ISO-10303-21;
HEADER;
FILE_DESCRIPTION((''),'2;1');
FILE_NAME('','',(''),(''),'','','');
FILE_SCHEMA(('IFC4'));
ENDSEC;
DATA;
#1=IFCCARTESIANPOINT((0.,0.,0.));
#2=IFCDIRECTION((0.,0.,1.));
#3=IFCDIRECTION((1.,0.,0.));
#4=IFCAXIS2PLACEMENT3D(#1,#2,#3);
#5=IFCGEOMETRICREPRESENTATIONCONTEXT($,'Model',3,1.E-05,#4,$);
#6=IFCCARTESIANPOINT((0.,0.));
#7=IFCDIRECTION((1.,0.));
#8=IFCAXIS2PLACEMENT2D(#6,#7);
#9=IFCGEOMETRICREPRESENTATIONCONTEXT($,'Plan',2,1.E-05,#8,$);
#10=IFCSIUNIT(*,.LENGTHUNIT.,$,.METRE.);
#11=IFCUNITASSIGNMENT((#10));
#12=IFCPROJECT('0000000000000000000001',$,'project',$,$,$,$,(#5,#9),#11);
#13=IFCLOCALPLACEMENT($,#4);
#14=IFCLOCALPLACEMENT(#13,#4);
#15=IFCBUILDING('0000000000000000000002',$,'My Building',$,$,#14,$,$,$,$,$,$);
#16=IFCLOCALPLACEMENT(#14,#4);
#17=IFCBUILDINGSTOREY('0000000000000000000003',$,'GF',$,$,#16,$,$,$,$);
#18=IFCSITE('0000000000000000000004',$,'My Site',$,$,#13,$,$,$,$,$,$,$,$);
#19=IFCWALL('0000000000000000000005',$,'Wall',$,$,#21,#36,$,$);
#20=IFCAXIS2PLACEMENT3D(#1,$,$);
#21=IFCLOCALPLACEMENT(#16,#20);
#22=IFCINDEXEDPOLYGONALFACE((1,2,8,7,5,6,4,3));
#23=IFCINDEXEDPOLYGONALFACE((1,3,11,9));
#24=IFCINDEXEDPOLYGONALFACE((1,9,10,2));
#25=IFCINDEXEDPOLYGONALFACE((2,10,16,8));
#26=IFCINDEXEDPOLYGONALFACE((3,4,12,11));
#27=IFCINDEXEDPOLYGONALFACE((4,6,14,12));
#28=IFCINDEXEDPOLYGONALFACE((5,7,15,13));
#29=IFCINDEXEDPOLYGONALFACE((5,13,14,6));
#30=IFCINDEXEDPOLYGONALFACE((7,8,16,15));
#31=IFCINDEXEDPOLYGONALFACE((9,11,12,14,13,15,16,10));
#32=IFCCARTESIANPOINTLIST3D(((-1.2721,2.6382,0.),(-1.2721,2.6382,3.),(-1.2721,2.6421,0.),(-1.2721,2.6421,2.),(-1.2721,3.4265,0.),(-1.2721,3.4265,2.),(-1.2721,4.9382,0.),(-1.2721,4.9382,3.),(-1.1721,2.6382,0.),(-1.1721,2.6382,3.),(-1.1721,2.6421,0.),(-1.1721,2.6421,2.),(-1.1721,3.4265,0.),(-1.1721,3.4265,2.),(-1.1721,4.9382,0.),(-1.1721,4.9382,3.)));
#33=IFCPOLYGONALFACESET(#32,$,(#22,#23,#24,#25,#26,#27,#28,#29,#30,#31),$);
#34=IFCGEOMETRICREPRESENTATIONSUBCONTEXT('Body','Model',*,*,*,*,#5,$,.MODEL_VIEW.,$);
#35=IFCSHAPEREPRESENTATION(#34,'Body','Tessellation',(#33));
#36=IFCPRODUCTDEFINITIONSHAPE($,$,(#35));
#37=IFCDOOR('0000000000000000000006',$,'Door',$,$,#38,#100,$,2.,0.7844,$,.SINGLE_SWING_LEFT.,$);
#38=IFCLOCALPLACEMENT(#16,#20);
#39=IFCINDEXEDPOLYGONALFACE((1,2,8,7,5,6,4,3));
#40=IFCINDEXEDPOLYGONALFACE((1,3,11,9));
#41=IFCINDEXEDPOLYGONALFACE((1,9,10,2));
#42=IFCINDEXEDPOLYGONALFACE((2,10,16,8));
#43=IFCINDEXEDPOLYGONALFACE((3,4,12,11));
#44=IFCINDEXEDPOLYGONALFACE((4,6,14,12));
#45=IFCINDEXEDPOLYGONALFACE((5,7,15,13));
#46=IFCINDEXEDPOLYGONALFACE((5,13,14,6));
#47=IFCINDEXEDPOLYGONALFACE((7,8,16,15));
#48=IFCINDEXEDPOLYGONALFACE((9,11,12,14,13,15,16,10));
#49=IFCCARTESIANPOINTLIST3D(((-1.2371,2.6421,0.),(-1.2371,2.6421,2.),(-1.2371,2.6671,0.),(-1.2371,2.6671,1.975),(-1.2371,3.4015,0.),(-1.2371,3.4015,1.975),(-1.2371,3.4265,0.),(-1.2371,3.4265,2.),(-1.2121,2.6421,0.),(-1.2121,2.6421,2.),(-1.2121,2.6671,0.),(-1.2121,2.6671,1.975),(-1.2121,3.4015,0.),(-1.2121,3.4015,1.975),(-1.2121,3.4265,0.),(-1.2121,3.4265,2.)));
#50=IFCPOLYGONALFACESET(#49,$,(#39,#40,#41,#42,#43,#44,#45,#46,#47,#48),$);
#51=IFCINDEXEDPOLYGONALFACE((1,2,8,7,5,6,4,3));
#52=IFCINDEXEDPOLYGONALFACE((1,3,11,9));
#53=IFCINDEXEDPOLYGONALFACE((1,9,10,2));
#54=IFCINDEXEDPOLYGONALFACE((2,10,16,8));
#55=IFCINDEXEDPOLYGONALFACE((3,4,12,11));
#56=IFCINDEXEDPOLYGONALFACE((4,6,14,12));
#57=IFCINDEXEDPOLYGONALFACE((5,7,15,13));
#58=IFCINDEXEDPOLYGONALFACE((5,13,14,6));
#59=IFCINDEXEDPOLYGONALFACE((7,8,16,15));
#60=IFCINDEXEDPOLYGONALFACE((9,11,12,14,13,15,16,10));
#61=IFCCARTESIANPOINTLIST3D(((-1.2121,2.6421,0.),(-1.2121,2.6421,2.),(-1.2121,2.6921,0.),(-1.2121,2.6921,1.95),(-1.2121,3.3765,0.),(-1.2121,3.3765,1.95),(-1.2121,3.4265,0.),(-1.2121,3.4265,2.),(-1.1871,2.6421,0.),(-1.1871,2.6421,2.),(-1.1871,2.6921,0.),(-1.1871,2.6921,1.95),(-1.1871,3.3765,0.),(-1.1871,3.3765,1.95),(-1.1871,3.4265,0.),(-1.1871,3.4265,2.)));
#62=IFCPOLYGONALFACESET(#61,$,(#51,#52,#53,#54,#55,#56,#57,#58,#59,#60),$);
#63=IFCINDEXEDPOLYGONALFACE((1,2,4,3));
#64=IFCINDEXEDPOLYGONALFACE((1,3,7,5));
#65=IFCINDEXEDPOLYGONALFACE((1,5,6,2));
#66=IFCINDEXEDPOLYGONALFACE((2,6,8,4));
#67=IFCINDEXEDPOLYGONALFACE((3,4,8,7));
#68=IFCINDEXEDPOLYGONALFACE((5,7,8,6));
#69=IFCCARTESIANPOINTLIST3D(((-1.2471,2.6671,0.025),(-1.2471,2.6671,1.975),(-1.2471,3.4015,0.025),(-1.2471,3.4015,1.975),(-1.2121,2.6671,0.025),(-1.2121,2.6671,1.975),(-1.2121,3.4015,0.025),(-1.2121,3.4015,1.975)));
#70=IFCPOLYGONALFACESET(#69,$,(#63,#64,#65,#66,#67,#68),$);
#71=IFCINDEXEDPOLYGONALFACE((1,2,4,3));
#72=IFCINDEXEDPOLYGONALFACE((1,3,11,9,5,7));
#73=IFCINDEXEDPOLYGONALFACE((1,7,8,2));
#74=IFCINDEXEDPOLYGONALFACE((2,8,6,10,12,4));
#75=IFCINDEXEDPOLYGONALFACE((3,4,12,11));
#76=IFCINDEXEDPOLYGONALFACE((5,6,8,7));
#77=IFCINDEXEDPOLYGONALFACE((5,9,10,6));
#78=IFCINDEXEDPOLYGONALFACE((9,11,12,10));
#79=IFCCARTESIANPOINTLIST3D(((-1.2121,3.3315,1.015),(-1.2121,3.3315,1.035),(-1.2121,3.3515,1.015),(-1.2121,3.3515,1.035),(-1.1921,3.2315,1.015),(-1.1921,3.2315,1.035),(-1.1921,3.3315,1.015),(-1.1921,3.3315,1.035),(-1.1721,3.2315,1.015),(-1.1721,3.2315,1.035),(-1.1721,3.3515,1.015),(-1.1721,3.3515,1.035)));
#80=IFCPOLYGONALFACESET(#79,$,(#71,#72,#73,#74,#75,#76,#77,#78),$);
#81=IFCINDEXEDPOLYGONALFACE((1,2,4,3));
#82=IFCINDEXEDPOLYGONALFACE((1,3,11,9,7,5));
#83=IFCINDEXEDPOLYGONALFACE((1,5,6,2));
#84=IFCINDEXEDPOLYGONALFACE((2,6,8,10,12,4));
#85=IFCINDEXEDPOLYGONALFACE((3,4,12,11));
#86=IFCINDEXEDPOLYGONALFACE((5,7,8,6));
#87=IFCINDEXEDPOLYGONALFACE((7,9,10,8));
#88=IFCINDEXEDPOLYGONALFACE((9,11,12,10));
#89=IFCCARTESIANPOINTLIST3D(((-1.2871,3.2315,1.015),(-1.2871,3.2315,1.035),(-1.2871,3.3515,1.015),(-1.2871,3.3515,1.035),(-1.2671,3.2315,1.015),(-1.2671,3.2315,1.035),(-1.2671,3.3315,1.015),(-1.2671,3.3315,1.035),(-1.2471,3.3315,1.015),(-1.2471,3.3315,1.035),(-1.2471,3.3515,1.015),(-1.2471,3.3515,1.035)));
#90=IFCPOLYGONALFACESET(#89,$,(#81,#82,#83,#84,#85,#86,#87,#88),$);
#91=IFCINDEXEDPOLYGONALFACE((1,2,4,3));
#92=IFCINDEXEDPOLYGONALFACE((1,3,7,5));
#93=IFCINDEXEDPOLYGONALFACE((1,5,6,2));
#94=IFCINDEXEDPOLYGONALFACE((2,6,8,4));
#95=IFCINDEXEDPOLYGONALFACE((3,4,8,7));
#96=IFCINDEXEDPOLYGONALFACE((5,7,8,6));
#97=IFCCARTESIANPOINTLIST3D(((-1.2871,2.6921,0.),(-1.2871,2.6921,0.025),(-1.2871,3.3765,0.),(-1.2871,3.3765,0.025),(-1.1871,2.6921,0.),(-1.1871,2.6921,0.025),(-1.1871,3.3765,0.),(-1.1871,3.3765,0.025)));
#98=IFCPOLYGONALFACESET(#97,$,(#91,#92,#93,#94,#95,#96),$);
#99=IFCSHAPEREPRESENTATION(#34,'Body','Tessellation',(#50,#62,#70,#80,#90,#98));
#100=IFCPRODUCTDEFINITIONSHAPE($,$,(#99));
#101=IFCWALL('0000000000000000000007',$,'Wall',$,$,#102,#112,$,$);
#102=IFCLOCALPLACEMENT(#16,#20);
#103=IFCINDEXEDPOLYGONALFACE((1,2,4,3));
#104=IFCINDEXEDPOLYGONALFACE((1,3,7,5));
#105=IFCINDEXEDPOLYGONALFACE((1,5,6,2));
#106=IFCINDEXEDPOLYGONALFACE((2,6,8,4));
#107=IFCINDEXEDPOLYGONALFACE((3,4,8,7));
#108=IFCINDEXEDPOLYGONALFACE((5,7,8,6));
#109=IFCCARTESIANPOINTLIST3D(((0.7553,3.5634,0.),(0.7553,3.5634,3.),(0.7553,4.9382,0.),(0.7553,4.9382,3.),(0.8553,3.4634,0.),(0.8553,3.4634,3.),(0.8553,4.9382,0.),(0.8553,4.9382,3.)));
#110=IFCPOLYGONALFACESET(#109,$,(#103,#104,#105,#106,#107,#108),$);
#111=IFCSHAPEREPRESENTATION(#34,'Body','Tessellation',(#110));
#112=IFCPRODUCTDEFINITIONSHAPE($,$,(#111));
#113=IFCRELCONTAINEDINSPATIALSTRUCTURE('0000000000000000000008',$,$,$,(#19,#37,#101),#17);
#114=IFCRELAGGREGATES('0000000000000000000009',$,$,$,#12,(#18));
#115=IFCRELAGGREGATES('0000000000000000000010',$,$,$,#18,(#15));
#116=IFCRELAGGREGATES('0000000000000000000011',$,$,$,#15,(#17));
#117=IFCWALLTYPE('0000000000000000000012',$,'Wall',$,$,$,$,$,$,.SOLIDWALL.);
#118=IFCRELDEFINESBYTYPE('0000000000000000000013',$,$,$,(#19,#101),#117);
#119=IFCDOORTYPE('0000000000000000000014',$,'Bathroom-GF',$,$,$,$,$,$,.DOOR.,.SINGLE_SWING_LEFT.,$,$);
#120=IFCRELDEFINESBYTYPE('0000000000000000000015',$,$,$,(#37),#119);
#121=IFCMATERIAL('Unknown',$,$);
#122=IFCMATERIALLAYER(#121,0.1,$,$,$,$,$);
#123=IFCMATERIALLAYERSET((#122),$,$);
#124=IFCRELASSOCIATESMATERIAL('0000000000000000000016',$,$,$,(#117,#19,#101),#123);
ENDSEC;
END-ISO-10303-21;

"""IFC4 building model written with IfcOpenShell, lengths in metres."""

from ifc_helpers import new_model, entity, si_unit, frame, origin_with_axes, origin_2d_with_axis, place, context, subcontext, project, spatial, line, indexed_curve, outline, extrude, shape, source, transform, mapped, material, layer, layer_set, layer_usage, type_object, type_shapes, element, fill, save


model = new_model("IFC4")

# Units and contexts
model_context = context("Model", 3, precision=1e-05, world=origin_with_axes())
plan_context = context("Plan", 2, precision=1e-05, world=origin_2d_with_axis())
body_context_1 = subcontext(model_context, "Body", "Model", "MODEL_VIEW")
body_context_2 = subcontext(plan_context, "Body", "Plan", "PLAN_VIEW")
ifc_project = project(units=[si_unit("LENGTHUNIT", "METRE")], contexts=[model_context, plan_context])

# Site, building, storey
site_placement = place(None, origin_with_axes())
site = spatial("IfcSite", under=ifc_project, at=site_placement, Name="My Site")
building_placement = place(site_placement, origin_with_axes())
building = spatial("IfcBuilding", under=site, at=building_placement, Name="My Building")
storey_placement = place(building_placement, origin_with_axes())
storey = spatial("IfcBuildingStorey", under=building, at=storey_placement, Name="GF")

# Shared definitions
ifc_material_1 = material(Name="Unknown")

# Shared definitions
ifc_layer_1 = layer(ifc_material_1, 0.1)
ifc_layer_set_1 = layer_set([ifc_layer_1])
wall_type = type_object("IfcWallType", Name="Wall", PredefinedType="SOLIDWALL", material=ifc_layer_set_1)

# Wall, opening, door
ifc_layer_usage_1 = layer_usage(ifc_layer_set_1, "AXIS2", "POSITIVE", 0.0)
wall_1_placement = place(storey_placement, frame((-1.1721, 2.6382, 0.0), z_axis=(0.0, 0.0, 1.0), x_axis=(0.0, 1.0, 0.0)))
wall_1 = element("IfcWall", 1, at=wall_1_placement, inside=storey, type_object=wall_type, material=ifc_layer_usage_1, Name="Wall", context=body_context_1, shape_type="SweptSolid", body=[
    extrude(outline(indexed_curve([(0.0, 0.0), (0.0, 0.1), (2.3, 0.1), (2.3, 0.0)], segments=[line(1, 2, 3, 4, 1)])), origin_with_axes(), (0.0, 0.0, 1.0), 3.0),
])
shared_shape_1 = source(origin_with_axes(), body_context_1, "Body", "SweptSolid", [
    extrude(outline(indexed_curve([(0.0, 0.0), (0.7844, 0.0), (0.7844, 2.0), (0.0, 2.0)], segments=[line(1, 2, 3, 4, 1)])), frame((0.0, -0.6, 0.0), z_axis=(0.0, -1.0, 0.0), x_axis=(1.0, 0.0, 0.0)), (0.0, 0.0, -1.0), 1.2),
])
opening_1_placement = place(wall_1_placement, frame((0.0039, 0.015, 0.0), z_axis=(0.0, 0.0, 1.0), x_axis=(1.0, 0.0, 0.0)))
opening_1 = element("IfcOpeningElement", 2, at=opening_1_placement, cuts=wall_1, PredefinedType="OPENING", context=body_context_1, shape_type="MappedRepresentation", body=[
    mapped(shared_shape_1, transform((0.0, 0.0, 0.0), x_axis=(1.0, 0.0, 0.0), y_axis=(0.0, 1.0, 0.0), z_axis=(0.0, 0.0, 1.0), scale=1.0)),
])
door_type_1 = type_object("IfcDoorType", Name="Bathroom-GF", OperationType="SINGLE_SWING_LEFT", PredefinedType="DOOR")
shared_shape_2 = source(origin_with_axes(), body_context_1, "Body", "SweptSolid", [
    extrude(outline(indexed_curve([(0.0, 0.0), (0.0, 2.0), (0.7844, 2.0), (0.7844, 0.0), (0.7594, 0.0), (0.7594, 1.975), (0.025, 1.975), (0.025, 0.0)], segments=[line(1, 2, 3, 4, 5, 6, 7, 8, 1)])), frame((0.0, 0.025, 0.0), z_axis=(0.0, -1.0, 0.0), x_axis=(1.0, 0.0, 0.0)), (0.0, 0.0, -1.0), 0.025),
    extrude(outline(indexed_curve([(0.0, 0.0), (0.0, 2.0), (0.7844, 2.0), (0.7844, 0.0), (0.7344, 0.0), (0.7344, 1.95), (0.05, 1.95), (0.05, 0.0)], segments=[line(1, 2, 3, 4, 5, 6, 7, 8, 1)])), frame((0.0, 0.0, 0.0), z_axis=(0.0, -1.0, 0.0), x_axis=(1.0, 0.0, 0.0)), (0.0, 0.0, -1.0), 0.025),
    extrude(outline(indexed_curve([(0.0, 0.0), (0.7344, 0.0), (0.7344, 0.035), (0.0, 0.035)], segments=[line(1, 2, 3, 4, 1)])), frame((0.025, 0.025, 0.025), z_axis=(0.0, 0.0, 1.0), x_axis=(1.0, 0.0, 0.0)), (0.0, 0.0, 1.0), 1.95),
    extrude(outline(indexed_curve([(0.0, 0.0), (0.0, -0.04), (-0.12, -0.04), (-0.12, -0.02), (-0.02, -0.02), (-0.02, 0.0)], segments=[line(1, 2, 3, 4, 5, 6, 1)])), frame((0.7094, 0.025, 1.015), z_axis=(0.0, 0.0, 1.0), x_axis=(1.0, 0.0, 0.0)), (0.0, 0.0, 1.0), 0.02),
    extrude(outline(indexed_curve([(0.0, 0.0), (0.0, 0.04), (-0.12, 0.04), (-0.12, 0.02), (-0.02, 0.02), (-0.02, 0.0)], segments=[line(1, 2, 3, 4, 5, 6, 1)])), frame((0.7094, 0.06, 1.015), z_axis=(0.0, 0.0, 1.0), x_axis=(1.0, 0.0, 0.0)), (0.0, 0.0, 1.0), 0.02),
    extrude(outline(indexed_curve([(0.0, 0.0), (0.6844, 0.0), (0.6844, 0.1), (0.0, 0.1)], segments=[line(1, 2, 3, 4, 1)])), frame((0.05, 0.0, 0.0), z_axis=(0.0, 0.0, 1.0), x_axis=(1.0, 0.0, 0.0)), (0.0, 0.0, 1.0), 0.025),
])
shared_shape_3 = source(origin_with_axes(), body_context_2, "Body", "Curve2D", [
    entity("IfcIndexedPolyCurve", entity("IfcCartesianPointList2D", [[0.0, 0.0], [0.0, 0.05], [0.025, 0.05], [0.025, 0.025], [0.05, 0.025], [0.05, 0.0]]), [entity("IfcLineIndex", [1, 2, 3, 4, 5, 6, 1])]),
    entity("IfcIndexedPolyCurve", entity("IfcCartesianPointList2D", [[0.7844, 0.0], [0.7844, 0.05], [0.7594, 0.05], [0.7594, 0.025], [0.7344, 0.025], [0.7344, 0.0]]), [entity("IfcLineIndex", [1, 2, 3, 4, 5, 6, 1])]),
    entity("IfcTrimmedCurve", entity("IfcEllipse", entity("IfcAxis2Placement2D", entity("IfcCartesianPoint", [0.06, 0.05]), entity("IfcDirection", [1.0, 0.0])), 0.6994, 0.7344), [entity("IfcCartesianPoint", [0.7594, 0.05])], [entity("IfcCartesianPoint", [0.06, 0.7844])], True, "CARTESIAN"),
    entity("IfcIndexedPolyCurve", entity("IfcCartesianPointList2D", [[0.025, 0.05], [0.06, 0.05], [0.06, 0.7844], [0.025, 0.7844]]), [entity("IfcLineIndex", [1, 2, 3, 4, 1])]),
])
type_shapes(door_type_1, [shared_shape_2, shared_shape_3])
door_1_placement = place(opening_1_placement, frame((0.0, 0.0, 0.0), z_axis=(0.0, 0.0, 1.0), x_axis=(1.0, 0.0, 0.0)))
door_1 = element("IfcDoor", 3, at=door_1_placement, inside=storey, type_object=door_type_1, Name="Door", OperationType="SINGLE_SWING_LEFT", OverallHeight=2.0, OverallWidth=0.7844, shapes=[
    shape(body_context_1, "Body", "MappedRepresentation", [mapped(shared_shape_2, transform((0.0, 0.0, 0.0), x_axis=(1.0, 0.0, 0.0), y_axis=(0.0, 1.0, 0.0), z_axis=(0.0, 0.0, 1.0), scale=1.0))]),
    shape(body_context_2, "Body", "MappedRepresentation", [mapped(shared_shape_3, transform((0.0, 0.0, 0.0), x_axis=(1.0, 0.0, 0.0), y_axis=(0.0, 1.0, 0.0), z_axis=(0.0, 0.0, 1.0), scale=1.0))]),
])
fill(opening_1, door_1)

# Wall
ifc_layer_usage_2 = layer_usage(ifc_layer_set_1, "AXIS2", "POSITIVE", 0.0)
wall_2_placement = place(storey_placement, frame((0.7553, 5.0382, 0.0), z_axis=(0.0, 0.0, 1.0), x_axis=(0.0, -1.0, 0.0)))
element("IfcWall", 4, at=wall_2_placement, inside=storey, type_object=wall_type, material=ifc_layer_usage_2, Name="Wall", context=body_context_1, shape_type="SweptSolid", body=[
    extrude(outline(indexed_curve([(0.1, 0.0), (0.1, 0.1), (1.5748, 0.1), (1.4748, 0.0)], segments=[line(1, 2, 3, 4, 1)])), origin_with_axes(), (0.0, 0.0, 1.0), 3.0),
])

save(model, "model.ifc")
